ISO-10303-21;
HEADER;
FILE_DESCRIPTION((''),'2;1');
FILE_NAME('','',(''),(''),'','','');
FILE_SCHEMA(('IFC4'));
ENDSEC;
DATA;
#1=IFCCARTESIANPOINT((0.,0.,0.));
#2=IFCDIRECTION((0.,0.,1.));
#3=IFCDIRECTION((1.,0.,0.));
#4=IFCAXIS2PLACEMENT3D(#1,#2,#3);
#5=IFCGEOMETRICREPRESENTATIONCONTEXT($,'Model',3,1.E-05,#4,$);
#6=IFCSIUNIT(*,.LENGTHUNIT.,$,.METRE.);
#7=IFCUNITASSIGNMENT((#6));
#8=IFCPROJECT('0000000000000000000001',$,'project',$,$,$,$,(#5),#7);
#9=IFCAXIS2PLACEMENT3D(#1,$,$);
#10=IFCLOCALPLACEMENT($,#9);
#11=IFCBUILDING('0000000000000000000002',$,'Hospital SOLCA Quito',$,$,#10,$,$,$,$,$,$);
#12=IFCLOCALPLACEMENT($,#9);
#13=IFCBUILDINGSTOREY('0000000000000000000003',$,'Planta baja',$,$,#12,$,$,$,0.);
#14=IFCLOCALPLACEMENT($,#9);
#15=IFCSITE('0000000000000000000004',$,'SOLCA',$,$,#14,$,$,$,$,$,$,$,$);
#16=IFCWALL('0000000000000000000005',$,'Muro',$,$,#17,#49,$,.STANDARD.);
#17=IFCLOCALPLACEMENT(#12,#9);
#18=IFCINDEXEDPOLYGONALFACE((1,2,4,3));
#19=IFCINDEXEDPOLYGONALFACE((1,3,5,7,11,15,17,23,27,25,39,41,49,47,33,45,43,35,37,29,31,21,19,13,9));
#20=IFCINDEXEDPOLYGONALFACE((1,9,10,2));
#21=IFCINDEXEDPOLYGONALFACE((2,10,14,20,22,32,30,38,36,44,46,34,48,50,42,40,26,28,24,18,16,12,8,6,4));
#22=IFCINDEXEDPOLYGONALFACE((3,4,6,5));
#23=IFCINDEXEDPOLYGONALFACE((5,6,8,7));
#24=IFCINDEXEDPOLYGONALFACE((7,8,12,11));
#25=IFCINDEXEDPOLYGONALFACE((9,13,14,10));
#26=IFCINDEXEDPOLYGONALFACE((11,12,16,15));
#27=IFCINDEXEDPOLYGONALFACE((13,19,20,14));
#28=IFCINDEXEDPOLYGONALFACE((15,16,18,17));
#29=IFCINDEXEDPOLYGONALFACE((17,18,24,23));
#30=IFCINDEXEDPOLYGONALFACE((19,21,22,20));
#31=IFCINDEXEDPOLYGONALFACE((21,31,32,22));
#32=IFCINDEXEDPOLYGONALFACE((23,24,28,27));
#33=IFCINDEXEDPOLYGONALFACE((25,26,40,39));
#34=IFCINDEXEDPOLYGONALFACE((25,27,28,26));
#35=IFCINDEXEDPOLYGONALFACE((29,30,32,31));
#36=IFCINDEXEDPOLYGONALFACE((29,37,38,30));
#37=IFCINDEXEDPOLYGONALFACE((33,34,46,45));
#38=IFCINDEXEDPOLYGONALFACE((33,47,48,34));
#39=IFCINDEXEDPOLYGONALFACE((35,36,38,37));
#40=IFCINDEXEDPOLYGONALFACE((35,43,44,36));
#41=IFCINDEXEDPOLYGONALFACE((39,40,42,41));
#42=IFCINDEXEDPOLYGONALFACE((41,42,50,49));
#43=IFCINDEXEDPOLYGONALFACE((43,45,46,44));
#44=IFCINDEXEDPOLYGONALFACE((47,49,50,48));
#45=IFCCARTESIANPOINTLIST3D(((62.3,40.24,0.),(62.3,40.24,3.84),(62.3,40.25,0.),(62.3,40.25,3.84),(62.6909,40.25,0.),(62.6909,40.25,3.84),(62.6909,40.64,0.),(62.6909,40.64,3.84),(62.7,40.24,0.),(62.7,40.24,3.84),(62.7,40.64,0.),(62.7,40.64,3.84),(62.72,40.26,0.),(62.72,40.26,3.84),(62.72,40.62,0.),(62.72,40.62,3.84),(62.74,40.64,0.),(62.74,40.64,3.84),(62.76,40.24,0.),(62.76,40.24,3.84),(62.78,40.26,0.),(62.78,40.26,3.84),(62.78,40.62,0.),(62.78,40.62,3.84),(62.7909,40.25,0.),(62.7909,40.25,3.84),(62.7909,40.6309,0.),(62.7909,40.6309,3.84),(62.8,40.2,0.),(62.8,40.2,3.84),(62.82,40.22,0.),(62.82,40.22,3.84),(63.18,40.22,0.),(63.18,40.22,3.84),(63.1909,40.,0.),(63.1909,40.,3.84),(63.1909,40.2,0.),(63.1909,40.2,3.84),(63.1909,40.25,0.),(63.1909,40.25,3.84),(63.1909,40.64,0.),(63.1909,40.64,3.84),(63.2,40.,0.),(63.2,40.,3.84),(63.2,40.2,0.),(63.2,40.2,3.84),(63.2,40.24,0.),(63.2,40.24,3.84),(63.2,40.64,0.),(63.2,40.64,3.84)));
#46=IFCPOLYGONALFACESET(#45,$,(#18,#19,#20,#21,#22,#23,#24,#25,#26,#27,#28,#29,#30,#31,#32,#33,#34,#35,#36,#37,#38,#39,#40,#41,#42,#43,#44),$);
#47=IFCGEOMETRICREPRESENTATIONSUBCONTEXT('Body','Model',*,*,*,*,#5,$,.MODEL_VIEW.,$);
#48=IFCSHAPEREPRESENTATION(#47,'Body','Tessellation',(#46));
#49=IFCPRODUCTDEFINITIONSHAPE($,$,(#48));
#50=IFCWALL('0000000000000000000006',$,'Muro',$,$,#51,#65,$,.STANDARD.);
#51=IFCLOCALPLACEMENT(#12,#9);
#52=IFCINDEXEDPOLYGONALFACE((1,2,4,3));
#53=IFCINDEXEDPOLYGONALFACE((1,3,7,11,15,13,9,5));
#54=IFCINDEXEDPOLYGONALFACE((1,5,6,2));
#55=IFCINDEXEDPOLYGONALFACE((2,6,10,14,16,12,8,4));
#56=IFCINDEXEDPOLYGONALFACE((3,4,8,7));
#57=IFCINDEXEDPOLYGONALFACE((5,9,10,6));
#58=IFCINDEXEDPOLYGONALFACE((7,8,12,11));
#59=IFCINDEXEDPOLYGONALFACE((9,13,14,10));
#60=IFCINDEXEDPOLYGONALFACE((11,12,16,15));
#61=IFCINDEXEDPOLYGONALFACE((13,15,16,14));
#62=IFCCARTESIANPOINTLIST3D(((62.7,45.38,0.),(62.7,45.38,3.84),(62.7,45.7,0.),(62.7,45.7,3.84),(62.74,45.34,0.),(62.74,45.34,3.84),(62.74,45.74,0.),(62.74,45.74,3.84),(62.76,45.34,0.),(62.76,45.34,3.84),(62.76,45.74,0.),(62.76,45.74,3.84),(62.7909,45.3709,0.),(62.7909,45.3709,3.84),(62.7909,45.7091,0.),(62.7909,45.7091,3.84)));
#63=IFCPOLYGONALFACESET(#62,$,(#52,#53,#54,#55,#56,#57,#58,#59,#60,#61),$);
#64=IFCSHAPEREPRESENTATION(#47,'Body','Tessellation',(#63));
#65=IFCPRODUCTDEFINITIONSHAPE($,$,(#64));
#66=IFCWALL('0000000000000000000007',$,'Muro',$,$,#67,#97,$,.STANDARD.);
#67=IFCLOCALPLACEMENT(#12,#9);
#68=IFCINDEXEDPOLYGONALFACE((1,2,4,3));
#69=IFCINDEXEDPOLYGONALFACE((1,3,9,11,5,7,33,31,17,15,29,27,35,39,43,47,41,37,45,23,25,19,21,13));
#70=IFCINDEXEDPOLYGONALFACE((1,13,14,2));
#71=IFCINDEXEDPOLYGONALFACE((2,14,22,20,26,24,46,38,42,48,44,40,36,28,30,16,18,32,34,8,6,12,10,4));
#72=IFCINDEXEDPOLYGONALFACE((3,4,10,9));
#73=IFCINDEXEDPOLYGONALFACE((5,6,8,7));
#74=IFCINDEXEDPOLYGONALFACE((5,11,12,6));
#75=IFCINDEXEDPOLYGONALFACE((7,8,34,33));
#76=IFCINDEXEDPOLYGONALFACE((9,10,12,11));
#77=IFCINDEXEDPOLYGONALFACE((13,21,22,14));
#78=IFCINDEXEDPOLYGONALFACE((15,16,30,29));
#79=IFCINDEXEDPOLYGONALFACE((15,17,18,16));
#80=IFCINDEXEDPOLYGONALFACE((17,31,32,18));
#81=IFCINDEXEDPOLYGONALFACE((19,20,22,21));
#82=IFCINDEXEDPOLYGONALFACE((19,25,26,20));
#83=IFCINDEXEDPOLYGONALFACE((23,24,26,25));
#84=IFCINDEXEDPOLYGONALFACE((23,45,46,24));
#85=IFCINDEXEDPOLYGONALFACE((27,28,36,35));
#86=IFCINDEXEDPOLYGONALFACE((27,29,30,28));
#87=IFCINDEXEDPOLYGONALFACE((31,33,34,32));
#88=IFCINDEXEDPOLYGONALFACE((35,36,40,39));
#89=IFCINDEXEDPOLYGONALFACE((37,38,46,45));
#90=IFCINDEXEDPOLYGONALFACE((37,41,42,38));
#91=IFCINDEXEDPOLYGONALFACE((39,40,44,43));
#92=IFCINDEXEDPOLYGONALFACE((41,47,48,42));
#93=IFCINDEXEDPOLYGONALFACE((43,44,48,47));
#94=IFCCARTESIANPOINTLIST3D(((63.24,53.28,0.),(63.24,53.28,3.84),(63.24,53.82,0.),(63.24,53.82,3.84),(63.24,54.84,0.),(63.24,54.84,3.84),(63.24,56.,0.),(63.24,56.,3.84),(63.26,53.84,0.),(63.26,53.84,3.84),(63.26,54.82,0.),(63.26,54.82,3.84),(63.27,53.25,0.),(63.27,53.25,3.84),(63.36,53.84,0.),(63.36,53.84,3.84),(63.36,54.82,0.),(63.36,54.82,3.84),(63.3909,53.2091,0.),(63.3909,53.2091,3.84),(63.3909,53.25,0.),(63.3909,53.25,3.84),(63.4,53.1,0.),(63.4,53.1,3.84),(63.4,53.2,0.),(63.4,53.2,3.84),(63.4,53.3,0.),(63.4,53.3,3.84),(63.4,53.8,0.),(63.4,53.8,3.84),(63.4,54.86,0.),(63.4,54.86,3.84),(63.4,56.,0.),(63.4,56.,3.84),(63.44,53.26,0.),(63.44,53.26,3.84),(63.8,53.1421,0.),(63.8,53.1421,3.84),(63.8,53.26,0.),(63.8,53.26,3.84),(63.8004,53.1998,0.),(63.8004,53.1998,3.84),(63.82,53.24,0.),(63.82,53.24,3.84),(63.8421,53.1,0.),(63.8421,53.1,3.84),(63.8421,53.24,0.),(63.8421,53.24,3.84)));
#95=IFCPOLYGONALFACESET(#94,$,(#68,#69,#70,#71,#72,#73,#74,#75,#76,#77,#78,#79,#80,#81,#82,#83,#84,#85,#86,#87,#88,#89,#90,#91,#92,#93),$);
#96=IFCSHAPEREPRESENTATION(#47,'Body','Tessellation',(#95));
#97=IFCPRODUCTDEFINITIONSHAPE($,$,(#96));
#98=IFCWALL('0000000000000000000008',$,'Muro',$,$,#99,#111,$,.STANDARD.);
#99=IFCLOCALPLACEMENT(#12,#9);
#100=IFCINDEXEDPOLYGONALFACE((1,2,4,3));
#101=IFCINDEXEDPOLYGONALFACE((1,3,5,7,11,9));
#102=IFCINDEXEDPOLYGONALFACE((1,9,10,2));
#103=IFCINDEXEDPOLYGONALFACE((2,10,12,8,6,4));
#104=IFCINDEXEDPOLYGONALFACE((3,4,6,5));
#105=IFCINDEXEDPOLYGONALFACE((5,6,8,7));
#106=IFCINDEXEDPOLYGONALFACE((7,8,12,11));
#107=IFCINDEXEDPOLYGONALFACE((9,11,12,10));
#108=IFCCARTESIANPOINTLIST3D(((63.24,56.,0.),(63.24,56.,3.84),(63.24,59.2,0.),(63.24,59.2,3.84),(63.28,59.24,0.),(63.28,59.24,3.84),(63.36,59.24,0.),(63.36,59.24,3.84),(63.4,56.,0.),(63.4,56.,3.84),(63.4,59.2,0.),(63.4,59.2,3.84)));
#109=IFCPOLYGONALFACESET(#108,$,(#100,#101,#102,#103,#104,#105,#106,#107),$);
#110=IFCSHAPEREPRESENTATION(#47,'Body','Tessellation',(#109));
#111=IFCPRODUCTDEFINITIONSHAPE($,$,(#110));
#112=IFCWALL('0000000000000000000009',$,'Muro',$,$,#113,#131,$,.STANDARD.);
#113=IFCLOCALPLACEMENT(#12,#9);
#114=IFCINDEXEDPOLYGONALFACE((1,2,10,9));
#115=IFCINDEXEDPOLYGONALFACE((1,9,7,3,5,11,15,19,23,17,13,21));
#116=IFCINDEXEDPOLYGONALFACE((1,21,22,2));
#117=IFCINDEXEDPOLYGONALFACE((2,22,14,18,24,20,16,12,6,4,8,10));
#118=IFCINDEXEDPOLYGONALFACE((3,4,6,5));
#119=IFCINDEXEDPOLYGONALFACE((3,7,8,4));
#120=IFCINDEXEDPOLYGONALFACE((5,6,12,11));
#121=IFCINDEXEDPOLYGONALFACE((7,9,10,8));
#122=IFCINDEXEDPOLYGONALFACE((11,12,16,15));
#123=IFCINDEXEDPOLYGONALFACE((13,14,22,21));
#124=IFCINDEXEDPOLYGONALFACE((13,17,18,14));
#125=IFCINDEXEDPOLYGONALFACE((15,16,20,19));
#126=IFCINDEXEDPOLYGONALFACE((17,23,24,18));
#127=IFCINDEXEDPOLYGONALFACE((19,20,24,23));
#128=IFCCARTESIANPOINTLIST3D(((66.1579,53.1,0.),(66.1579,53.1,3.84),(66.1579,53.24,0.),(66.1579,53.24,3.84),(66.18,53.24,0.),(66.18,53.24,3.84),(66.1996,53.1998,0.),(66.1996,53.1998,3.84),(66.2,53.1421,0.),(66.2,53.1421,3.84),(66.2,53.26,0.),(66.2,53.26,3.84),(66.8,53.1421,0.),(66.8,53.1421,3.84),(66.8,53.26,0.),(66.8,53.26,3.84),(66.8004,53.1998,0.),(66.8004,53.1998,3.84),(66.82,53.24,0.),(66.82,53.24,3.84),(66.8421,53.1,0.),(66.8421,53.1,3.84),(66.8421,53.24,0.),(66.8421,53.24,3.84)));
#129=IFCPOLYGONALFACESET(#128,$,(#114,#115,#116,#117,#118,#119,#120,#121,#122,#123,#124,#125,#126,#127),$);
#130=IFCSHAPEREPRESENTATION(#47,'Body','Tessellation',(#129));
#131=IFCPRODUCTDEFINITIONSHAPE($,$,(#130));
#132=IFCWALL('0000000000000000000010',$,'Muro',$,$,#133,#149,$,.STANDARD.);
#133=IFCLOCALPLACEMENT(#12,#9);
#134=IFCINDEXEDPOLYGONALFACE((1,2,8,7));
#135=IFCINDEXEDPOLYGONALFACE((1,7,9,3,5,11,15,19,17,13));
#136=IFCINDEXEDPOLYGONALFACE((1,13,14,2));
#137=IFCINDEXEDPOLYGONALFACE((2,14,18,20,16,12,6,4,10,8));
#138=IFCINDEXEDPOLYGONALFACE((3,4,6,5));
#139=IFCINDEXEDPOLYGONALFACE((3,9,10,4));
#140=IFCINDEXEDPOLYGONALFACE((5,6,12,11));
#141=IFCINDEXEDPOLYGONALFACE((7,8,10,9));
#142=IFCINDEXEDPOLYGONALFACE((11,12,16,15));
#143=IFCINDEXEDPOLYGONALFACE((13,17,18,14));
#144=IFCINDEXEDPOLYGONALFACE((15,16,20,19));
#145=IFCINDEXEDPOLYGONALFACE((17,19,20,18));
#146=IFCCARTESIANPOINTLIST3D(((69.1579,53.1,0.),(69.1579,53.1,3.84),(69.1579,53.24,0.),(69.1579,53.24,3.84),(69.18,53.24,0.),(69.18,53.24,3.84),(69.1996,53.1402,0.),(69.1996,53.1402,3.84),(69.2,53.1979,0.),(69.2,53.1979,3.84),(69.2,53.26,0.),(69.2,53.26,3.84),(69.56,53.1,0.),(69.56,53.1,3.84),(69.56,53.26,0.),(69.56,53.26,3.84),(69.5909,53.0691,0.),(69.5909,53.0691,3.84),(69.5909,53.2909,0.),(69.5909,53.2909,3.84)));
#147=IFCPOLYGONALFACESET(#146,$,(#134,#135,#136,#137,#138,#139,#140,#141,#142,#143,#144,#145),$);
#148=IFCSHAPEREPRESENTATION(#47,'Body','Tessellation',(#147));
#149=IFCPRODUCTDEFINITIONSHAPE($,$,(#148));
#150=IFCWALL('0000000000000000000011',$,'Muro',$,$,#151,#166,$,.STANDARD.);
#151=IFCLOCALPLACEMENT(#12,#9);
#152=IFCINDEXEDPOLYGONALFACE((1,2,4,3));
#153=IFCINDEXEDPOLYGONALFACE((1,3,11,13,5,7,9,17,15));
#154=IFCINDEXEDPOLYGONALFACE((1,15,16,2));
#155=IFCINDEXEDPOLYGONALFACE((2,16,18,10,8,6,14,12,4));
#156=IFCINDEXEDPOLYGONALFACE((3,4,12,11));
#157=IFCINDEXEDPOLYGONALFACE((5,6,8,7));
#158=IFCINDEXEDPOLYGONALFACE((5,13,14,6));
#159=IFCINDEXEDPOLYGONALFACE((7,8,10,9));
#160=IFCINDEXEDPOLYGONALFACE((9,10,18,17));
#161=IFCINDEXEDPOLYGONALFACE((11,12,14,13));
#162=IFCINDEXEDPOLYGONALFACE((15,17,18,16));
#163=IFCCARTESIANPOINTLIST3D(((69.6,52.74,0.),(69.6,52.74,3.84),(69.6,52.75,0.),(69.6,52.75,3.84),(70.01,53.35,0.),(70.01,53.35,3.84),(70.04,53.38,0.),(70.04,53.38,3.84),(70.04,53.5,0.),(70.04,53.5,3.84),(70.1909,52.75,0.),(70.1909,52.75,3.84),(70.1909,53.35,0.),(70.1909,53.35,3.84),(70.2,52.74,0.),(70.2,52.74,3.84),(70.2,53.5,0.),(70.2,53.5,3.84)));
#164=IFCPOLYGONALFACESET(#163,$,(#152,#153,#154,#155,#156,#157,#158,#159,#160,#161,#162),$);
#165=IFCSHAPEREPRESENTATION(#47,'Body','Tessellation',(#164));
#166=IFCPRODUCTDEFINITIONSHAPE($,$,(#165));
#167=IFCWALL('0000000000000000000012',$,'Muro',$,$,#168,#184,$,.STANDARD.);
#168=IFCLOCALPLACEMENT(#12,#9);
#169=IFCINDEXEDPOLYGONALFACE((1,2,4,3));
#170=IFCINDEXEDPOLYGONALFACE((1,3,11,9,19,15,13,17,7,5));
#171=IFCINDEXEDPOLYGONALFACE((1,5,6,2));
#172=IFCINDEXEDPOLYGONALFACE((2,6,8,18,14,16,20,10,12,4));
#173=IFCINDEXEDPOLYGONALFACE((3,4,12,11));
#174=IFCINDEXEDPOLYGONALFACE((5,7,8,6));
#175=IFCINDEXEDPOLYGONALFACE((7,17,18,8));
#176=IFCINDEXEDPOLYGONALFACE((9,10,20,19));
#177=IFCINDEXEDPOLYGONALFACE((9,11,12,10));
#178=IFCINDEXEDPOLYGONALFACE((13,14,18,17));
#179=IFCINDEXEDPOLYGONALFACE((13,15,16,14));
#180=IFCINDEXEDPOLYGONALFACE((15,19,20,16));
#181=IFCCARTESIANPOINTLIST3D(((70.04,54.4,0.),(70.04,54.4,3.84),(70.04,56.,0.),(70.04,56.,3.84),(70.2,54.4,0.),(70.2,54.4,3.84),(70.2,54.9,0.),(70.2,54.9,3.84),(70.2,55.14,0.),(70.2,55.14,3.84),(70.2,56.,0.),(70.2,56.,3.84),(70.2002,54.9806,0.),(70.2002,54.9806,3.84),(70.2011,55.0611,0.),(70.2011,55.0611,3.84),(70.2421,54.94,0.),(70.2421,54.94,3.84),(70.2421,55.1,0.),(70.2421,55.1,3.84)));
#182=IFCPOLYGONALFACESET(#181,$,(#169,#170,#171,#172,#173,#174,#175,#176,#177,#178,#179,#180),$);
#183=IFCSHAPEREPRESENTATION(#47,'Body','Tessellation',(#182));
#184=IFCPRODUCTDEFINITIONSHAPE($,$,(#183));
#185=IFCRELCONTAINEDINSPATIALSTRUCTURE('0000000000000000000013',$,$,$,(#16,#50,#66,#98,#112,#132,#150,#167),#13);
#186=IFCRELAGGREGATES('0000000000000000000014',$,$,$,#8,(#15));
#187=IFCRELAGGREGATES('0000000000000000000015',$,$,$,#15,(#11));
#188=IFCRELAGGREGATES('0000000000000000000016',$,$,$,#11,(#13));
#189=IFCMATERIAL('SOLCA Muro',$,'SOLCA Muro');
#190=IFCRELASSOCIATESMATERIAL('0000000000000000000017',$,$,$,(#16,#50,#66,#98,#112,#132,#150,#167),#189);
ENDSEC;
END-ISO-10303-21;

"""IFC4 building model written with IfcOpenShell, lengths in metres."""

from ifc_helpers import new_model, si_unit, origin, origin_with_axes, place, context, subcontext, project, spatial, polyline, outline, extrude, material, element, save


model = new_model("IFC4")

# Units and contexts
model_context = context("Model", 3, precision=1e-05, world=origin_with_axes())
body_context = subcontext(model_context, "Body", "Model", "MODEL_VIEW")
ifc_project = project(units=[si_unit("LENGTHUNIT", "METRE")], contexts=[model_context])

# Site, building, storey
site_placement = place(None, origin())
site = spatial("IfcSite", under=ifc_project, at=site_placement, Name="SOLCA")
building_placement = place(None, origin())
building = spatial("IfcBuilding", under=site, at=building_placement, Name="Hospital SOLCA Quito")
storey_placement = place(None, origin())
storey = spatial("IfcBuildingStorey", under=building, at=storey_placement, Name="Planta baja", Elevation=0.0)

# Walls
ifc_material = material(Name="SOLCA Muro", Category="SOLCA Muro")
wall_1_placement = place(storey_placement, origin_with_axes())
element("IfcWall", 1, at=wall_1_placement, inside=storey, material=ifc_material, Name="Muro", PredefinedType="STANDARD", context=body_context, shape_type="SweptSolid", body=[
    extrude(outline(polyline([(62.76, 40.24), (62.72, 40.26), (62.7, 40.24), (62.3, 40.24), (62.3, 40.25), (62.6909, 40.25), (62.6909, 40.64), (62.7, 40.64), (62.72, 40.62), (62.74, 40.64), (62.78, 40.62), (62.7909, 40.6309), (62.7909, 40.25), (63.1909, 40.25), (63.1909, 40.64), (63.2, 40.64), (63.2, 40.24), (63.18, 40.22), (63.2, 40.2), (63.2, 40.0), (63.1909, 40.0), (63.1909, 40.2), (62.8, 40.2), (62.82, 40.22), (62.78, 40.26), (62.76, 40.24)])), origin_with_axes(), (0.0, 0.0, 1.0), 3.84),
])
wall_2_placement = place(storey_placement, origin_with_axes())
element("IfcWall", 2, at=wall_2_placement, inside=storey, material=ifc_material, Name="Muro", PredefinedType="STANDARD", context=body_context, shape_type="SweptSolid", body=[
    extrude(outline(polyline([(62.7909, 45.3709), (62.76, 45.34), (62.74, 45.34), (62.7, 45.38), (62.7, 45.7), (62.74, 45.74), (62.76, 45.74), (62.7909, 45.7091), (62.7909, 45.3709)])), origin_with_axes(), (0.0, 0.0, 1.0), 3.84),
])
wall_3_placement = place(storey_placement, origin_with_axes())
element("IfcWall", 3, at=wall_3_placement, inside=storey, material=ifc_material, Name="Muro", PredefinedType="STANDARD", context=body_context, shape_type="SweptSolid", body=[
    extrude(outline(polyline([(63.8421, 53.24), (63.8004, 53.1998), (63.8, 53.1421), (63.8421, 53.1), (63.4, 53.1), (63.4, 53.2), (63.3909, 53.2091), (63.3909, 53.25), (63.27, 53.25), (63.24, 53.28), (63.24, 53.82), (63.26, 53.84), (63.26, 54.82), (63.24, 54.84), (63.24, 56.0), (63.4, 56.0), (63.4, 54.86), (63.36, 54.82), (63.36, 53.84), (63.4, 53.8), (63.4, 53.3), (63.44, 53.26), (63.8, 53.26), (63.82, 53.24), (63.8421, 53.24)])), origin_with_axes(), (0.0, 0.0, 1.0), 3.84),
])
wall_4_placement = place(storey_placement, origin_with_axes())
element("IfcWall", 4, at=wall_4_placement, inside=storey, material=ifc_material, Name="Muro", PredefinedType="STANDARD", context=body_context, shape_type="SweptSolid", body=[
    extrude(outline(polyline([(63.24, 59.2), (63.28, 59.24), (63.36, 59.24), (63.4, 59.2), (63.4, 56.0), (63.24, 56.0), (63.24, 59.2)])), origin_with_axes(), (0.0, 0.0, 1.0), 3.84),
])
wall_5_placement = place(storey_placement, origin_with_axes())
element("IfcWall", 5, at=wall_5_placement, inside=storey, material=ifc_material, Name="Muro", PredefinedType="STANDARD", context=body_context, shape_type="SweptSolid", body=[
    extrude(outline(polyline([(66.8421, 53.24), (66.8004, 53.1998), (66.8, 53.1421), (66.8421, 53.1), (66.1579, 53.1), (66.2, 53.1421), (66.1996, 53.1998), (66.1579, 53.24), (66.18, 53.24), (66.2, 53.26), (66.8, 53.26), (66.82, 53.24), (66.8421, 53.24)])), origin_with_axes(), (0.0, 0.0, 1.0), 3.84),
])
wall_6_placement = place(storey_placement, origin_with_axes())
element("IfcWall", 6, at=wall_6_placement, inside=storey, material=ifc_material, Name="Muro", PredefinedType="STANDARD", context=body_context, shape_type="SweptSolid", body=[
    extrude(outline(polyline([(69.1579, 53.1), (69.1996, 53.1402), (69.2, 53.1979), (69.1579, 53.24), (69.18, 53.24), (69.2, 53.26), (69.56, 53.26), (69.5909, 53.2909), (69.5909, 53.0691), (69.56, 53.1), (69.1579, 53.1)])), origin_with_axes(), (0.0, 0.0, 1.0), 3.84),
])
wall_7_placement = place(storey_placement, origin_with_axes())
element("IfcWall", 7, at=wall_7_placement, inside=storey, material=ifc_material, Name="Muro", PredefinedType="STANDARD", context=body_context, shape_type="SweptSolid", body=[
    extrude(outline(polyline([(70.2, 53.5), (70.2, 52.74), (69.6, 52.74), (69.6, 52.75), (70.1909, 52.75), (70.1909, 53.35), (70.01, 53.35), (70.04, 53.38), (70.04, 53.5), (70.2, 53.5)])), origin_with_axes(), (0.0, 0.0, 1.0), 3.84),
])
wall_8_placement = place(storey_placement, origin_with_axes())
element("IfcWall", 8, at=wall_8_placement, inside=storey, material=ifc_material, Name="Muro", PredefinedType="STANDARD", context=body_context, shape_type="SweptSolid", body=[
    extrude(outline(polyline([(70.2011, 55.0611), (70.2002, 54.9806), (70.2421, 54.94), (70.2, 54.9), (70.2, 54.4), (70.04, 54.4), (70.04, 56.0), (70.2, 56.0), (70.2, 55.14), (70.2421, 55.1), (70.2011, 55.0611)])), origin_with_axes(), (0.0, 0.0, 1.0), 3.84),
])

save(model, "model.ifc")
